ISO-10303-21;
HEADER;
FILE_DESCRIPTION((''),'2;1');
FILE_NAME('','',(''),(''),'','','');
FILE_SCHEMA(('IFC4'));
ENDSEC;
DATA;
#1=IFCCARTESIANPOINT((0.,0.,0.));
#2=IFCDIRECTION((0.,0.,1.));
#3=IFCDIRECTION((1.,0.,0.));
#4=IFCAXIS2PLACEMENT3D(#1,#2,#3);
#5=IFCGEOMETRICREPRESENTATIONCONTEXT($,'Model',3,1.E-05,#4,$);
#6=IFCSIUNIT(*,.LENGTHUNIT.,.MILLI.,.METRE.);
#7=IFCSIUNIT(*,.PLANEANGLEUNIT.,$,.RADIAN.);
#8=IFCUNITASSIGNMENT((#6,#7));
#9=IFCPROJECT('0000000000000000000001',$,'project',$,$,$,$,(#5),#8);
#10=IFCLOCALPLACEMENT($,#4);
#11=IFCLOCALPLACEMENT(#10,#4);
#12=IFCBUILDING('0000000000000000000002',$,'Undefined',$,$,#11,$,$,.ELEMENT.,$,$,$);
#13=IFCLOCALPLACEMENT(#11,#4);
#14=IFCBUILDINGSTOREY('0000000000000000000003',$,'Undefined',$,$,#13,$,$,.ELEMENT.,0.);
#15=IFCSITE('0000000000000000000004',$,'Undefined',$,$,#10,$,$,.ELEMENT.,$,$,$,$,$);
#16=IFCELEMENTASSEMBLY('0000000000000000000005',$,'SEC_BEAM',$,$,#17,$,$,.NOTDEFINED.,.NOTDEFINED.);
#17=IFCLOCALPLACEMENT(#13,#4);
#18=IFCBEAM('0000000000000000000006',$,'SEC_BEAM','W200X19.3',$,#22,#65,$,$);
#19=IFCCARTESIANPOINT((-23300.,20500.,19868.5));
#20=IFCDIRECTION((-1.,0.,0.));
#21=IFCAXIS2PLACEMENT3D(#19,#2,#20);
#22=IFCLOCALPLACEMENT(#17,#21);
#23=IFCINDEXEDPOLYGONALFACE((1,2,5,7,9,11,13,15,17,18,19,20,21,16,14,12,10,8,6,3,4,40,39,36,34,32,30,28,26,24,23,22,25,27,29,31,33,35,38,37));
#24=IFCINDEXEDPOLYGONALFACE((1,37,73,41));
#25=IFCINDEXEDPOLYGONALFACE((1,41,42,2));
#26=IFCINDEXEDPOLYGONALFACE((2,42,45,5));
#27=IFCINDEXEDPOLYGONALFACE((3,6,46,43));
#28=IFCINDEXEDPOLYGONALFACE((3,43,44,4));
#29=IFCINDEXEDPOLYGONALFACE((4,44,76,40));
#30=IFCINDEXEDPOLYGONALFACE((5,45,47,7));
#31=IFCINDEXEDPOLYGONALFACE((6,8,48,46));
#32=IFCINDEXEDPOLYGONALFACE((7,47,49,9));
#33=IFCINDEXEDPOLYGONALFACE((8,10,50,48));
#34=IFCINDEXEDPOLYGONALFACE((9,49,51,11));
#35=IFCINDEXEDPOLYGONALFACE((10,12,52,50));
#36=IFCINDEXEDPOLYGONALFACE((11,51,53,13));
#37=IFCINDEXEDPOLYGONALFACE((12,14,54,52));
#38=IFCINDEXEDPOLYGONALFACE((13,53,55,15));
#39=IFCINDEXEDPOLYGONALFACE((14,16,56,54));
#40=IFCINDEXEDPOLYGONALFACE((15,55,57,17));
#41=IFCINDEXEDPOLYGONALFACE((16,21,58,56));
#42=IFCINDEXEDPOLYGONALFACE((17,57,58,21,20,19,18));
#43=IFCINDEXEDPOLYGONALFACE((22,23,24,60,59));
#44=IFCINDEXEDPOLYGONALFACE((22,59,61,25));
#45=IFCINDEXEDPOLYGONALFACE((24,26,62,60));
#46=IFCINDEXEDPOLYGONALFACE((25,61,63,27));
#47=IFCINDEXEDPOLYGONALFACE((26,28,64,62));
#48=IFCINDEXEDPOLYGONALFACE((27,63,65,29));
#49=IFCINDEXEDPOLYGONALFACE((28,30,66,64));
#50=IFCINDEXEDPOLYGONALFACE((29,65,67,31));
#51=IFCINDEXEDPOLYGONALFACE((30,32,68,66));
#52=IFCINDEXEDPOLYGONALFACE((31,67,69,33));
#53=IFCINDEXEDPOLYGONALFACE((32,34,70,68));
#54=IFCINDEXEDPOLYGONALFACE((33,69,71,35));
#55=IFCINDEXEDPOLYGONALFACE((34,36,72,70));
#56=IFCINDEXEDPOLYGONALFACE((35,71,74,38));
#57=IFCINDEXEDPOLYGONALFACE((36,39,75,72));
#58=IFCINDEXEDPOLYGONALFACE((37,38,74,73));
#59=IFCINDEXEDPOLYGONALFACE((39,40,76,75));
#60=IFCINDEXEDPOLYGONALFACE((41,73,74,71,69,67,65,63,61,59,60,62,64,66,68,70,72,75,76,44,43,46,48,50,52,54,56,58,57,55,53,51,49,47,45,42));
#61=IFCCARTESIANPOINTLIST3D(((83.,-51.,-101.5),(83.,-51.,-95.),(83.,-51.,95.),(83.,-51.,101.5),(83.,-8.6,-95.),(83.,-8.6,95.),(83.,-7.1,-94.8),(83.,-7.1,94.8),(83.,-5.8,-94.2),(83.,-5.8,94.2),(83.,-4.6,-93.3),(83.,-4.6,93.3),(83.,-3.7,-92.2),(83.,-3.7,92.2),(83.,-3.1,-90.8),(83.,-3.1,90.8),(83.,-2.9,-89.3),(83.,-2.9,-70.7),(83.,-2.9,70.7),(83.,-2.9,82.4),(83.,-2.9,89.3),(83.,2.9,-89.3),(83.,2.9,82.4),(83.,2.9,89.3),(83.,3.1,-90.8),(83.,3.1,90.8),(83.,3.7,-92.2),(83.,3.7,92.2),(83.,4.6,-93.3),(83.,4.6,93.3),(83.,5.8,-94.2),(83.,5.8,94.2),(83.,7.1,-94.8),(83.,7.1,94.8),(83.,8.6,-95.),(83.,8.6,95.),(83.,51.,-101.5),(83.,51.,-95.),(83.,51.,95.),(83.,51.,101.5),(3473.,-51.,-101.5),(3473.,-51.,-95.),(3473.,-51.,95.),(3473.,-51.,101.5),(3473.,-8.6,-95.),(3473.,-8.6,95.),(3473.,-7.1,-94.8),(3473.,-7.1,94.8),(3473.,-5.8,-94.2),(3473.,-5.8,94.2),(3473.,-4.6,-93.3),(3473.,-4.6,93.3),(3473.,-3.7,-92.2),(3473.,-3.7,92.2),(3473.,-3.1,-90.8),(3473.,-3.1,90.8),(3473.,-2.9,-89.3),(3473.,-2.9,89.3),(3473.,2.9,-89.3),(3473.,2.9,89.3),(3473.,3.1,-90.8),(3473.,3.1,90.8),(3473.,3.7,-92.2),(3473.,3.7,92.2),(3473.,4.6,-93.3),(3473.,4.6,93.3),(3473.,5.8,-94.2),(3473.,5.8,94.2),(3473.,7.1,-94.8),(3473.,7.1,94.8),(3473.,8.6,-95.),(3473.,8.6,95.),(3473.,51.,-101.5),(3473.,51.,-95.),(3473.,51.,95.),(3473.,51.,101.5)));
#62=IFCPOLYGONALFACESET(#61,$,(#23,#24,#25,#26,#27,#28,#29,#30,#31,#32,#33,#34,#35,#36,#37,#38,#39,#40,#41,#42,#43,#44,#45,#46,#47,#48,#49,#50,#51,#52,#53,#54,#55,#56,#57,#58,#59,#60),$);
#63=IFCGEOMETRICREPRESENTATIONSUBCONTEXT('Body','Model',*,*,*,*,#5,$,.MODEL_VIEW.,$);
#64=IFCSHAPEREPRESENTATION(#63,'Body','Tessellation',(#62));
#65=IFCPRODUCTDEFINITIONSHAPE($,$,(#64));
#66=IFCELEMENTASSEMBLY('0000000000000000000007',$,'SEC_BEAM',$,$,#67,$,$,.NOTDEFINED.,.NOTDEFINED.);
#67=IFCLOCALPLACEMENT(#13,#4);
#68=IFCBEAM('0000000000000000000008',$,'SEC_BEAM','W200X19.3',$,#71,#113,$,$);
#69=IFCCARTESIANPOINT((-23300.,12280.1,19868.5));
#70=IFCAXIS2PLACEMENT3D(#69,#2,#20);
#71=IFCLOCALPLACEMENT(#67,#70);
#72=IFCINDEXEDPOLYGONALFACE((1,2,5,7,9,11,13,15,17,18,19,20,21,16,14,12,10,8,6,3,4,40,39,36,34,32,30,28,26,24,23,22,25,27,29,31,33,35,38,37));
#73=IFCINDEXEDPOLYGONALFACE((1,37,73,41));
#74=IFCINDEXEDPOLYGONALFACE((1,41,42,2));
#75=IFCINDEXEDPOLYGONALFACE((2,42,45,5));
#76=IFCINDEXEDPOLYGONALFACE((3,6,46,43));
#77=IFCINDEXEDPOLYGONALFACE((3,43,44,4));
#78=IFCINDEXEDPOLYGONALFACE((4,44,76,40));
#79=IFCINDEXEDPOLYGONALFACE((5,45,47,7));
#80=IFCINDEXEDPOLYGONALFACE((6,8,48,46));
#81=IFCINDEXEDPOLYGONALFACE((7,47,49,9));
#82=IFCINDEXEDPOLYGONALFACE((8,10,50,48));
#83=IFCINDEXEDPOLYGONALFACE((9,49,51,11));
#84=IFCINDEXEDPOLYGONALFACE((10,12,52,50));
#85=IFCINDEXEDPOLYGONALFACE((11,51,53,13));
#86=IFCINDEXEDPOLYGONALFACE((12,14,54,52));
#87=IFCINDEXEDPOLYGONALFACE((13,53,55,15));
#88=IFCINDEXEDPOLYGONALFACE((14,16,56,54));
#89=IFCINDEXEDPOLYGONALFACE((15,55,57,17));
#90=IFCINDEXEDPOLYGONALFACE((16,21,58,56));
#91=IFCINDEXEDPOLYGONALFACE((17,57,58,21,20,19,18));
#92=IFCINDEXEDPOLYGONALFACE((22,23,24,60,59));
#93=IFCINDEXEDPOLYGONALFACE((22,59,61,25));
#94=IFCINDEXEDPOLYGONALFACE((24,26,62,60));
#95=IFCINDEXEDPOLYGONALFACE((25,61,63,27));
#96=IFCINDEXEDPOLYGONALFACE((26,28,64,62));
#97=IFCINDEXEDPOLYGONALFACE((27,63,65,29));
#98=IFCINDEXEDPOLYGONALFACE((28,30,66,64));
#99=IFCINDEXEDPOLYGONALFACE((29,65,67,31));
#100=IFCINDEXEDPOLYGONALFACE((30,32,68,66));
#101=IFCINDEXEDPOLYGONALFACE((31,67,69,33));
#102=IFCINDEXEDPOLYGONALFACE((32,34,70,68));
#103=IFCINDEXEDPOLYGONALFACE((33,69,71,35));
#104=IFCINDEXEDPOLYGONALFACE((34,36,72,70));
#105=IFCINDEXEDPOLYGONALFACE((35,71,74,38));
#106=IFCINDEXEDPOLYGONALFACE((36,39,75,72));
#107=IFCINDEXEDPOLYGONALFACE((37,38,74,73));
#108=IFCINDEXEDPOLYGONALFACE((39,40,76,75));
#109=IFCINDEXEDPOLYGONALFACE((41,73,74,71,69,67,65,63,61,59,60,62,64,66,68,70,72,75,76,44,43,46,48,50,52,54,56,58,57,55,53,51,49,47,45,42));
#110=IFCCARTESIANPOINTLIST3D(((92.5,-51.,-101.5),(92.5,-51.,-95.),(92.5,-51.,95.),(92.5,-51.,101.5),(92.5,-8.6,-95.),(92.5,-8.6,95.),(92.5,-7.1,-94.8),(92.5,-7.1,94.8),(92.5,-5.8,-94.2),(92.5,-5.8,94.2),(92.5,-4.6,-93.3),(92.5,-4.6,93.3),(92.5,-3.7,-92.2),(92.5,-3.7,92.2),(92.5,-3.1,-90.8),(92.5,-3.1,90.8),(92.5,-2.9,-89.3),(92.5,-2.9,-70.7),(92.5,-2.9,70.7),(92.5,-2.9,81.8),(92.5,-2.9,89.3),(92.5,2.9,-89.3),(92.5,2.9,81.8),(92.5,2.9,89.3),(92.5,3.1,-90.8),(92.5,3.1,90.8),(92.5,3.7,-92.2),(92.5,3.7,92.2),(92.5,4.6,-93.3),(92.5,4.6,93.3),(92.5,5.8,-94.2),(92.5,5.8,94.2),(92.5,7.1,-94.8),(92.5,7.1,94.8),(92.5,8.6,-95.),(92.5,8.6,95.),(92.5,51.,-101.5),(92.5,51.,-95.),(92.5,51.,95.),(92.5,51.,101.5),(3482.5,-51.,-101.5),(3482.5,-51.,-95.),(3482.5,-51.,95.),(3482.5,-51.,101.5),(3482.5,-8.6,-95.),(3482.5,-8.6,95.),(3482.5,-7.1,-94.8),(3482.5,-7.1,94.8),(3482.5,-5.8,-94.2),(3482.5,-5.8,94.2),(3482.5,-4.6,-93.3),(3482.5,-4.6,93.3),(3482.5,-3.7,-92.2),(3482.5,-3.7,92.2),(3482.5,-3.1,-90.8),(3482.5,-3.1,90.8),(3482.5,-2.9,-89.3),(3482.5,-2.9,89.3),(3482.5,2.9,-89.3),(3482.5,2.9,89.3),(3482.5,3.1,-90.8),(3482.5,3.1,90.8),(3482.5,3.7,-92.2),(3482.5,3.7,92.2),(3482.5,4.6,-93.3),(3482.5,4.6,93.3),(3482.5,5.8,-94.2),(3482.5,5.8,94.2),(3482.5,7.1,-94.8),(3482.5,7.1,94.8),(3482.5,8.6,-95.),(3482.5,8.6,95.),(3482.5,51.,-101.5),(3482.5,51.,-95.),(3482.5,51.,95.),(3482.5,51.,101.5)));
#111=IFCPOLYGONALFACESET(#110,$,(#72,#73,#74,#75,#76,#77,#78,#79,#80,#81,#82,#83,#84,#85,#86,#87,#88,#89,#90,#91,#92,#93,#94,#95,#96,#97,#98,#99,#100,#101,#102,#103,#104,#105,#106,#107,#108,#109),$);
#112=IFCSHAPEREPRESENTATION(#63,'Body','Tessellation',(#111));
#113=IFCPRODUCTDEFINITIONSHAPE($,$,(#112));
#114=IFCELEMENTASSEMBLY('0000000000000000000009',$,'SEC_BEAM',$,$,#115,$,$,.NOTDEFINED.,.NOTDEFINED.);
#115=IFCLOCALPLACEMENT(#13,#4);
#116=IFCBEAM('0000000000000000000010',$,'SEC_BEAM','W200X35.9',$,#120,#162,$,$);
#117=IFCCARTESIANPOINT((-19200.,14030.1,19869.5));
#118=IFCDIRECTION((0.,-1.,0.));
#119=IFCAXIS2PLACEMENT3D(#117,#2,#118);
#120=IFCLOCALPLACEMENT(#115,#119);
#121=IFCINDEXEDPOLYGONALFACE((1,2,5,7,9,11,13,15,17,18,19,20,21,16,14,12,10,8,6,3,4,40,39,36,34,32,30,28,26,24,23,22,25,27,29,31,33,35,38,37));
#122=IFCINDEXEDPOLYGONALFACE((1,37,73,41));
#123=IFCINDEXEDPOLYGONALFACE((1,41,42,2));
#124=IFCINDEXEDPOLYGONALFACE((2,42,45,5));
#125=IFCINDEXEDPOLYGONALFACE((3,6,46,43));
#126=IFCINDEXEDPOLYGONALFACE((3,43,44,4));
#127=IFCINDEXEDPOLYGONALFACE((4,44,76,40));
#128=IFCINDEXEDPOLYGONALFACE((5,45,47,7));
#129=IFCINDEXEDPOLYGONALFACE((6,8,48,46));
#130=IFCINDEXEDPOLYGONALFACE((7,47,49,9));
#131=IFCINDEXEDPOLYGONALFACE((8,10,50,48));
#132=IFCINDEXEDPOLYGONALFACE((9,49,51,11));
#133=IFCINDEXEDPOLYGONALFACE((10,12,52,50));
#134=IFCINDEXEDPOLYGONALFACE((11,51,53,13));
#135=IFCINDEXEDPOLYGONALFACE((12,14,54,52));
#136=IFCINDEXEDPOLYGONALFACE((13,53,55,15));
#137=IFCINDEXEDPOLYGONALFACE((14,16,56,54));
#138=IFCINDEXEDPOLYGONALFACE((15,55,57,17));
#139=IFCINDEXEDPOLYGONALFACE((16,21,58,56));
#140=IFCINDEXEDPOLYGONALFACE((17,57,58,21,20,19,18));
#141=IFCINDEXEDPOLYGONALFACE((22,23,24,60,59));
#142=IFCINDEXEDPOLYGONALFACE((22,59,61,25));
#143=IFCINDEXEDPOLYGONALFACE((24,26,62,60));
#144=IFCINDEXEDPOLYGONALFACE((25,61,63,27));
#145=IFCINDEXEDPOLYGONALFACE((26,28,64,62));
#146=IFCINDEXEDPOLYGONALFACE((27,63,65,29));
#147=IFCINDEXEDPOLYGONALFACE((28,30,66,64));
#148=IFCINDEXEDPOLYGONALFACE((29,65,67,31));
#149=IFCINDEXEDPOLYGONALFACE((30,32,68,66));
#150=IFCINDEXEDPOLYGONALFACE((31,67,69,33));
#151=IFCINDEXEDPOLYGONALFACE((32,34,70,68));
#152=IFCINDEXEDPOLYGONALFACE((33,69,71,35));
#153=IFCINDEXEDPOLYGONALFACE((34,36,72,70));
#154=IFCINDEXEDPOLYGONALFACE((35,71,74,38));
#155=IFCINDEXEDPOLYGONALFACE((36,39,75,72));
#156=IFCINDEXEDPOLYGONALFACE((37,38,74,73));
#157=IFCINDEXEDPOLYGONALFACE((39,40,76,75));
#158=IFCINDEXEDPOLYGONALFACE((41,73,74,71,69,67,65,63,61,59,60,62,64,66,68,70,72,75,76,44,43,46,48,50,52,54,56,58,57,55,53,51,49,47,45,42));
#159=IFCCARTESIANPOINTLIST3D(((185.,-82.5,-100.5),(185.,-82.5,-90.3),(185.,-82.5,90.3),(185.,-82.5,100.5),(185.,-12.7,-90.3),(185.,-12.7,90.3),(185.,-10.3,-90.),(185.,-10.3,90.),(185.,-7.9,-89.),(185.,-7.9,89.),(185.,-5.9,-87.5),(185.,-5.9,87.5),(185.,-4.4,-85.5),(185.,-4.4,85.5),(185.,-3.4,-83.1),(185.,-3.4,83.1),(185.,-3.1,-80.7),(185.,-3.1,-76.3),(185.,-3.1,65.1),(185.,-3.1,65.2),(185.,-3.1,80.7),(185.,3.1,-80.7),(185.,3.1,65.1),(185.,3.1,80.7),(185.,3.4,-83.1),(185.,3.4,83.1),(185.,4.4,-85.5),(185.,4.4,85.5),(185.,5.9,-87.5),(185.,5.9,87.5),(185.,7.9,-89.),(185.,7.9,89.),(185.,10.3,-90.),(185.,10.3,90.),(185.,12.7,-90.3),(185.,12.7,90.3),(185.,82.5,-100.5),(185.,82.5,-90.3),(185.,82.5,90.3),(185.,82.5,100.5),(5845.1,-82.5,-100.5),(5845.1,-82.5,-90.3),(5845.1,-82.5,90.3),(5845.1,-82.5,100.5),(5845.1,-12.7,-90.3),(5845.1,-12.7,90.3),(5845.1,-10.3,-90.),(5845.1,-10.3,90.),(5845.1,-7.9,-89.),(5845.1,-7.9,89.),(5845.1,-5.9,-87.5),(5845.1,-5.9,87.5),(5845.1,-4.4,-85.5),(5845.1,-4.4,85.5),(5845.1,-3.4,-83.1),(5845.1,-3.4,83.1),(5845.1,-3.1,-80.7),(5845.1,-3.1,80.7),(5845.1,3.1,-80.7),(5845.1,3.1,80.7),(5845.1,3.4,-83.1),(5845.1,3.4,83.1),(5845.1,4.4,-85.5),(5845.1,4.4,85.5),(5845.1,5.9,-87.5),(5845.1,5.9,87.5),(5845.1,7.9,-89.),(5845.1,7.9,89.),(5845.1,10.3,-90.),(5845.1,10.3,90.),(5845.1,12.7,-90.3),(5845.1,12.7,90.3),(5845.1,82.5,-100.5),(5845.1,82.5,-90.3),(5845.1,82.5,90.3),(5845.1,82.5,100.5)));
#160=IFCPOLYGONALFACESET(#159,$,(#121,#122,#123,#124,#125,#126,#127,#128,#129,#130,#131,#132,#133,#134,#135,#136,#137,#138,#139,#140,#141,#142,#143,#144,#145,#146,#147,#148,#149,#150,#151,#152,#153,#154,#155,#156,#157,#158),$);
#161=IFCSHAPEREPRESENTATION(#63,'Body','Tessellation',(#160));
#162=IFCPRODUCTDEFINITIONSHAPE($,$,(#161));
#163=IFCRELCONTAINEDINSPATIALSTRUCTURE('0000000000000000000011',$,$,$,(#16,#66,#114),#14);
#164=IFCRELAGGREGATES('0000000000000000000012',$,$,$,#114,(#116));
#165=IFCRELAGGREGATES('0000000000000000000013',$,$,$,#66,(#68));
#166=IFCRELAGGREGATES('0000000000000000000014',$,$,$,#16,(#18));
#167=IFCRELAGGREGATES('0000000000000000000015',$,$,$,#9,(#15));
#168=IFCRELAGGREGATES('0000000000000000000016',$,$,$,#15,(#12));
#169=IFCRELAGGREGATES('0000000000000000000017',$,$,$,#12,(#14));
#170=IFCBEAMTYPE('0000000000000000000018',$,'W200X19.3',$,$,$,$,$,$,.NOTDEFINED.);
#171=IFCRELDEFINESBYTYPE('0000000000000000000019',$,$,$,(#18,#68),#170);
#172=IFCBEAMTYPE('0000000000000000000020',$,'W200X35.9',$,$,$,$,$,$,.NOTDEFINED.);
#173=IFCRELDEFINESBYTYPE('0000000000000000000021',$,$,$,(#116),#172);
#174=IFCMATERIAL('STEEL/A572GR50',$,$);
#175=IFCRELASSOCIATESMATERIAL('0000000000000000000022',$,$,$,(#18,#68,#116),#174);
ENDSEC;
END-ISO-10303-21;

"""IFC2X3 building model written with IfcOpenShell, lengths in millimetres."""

from ifc_helpers import new_model, si_unit, frame, origin_with_axes, origin_2d_with_axis, place, context, subcontext, project, spatial, polyline, rectangle, i_section, outline, extrude, boolean, halfspace, material, type_object, element, aggregate, save


model = new_model("IFC2X3")

# Units and contexts
model_context = context("Model", 3, precision=1e-05, world=origin_with_axes())
body_context = subcontext(model_context, "Body", "Model", "MODEL_VIEW")
ifc_project = project(units=[si_unit("LENGTHUNIT", "METRE", prefix="MILLI"), si_unit("PLANEANGLEUNIT", "RADIAN")], contexts=[model_context])

# Site, building, storey
site_placement = place(None, origin_with_axes())
site = spatial("IfcSite", under=ifc_project, at=site_placement, Name="Undefined", CompositionType="ELEMENT")
building_placement = place(site_placement, origin_with_axes())
building = spatial("IfcBuilding", under=site, at=building_placement, Name="Undefined", CompositionType="ELEMENT")
storey_placement = place(building_placement, origin_with_axes())
storey = spatial("IfcBuildingStorey", under=building, at=storey_placement, Name="Undefined", CompositionType="ELEMENT", Elevation=0.0)

# Element assemblies, beams
assembly_1_placement = place(storey_placement, origin_with_axes())
assembly_1 = element("IfcElementAssembly", 1, at=assembly_1_placement, inside=storey, Name="SEC_BEAM", AssemblyPlace="NOTDEFINED", PredefinedType="NOTDEFINED")
ifc_material_1 = material(Name="STEEL/A572GR50")
beam_type_1 = type_object("IfcBeamType", Name="W200X19.3", PredefinedType="NOTDEFINED")
beam_1_placement = place(assembly_1_placement, frame((-23300.0, 20500.0, 19868.5), z_axis=(0.0, 0.0, 1.0), x_axis=(-1.0, 0.0, 0.0)))
beam_1 = element("IfcBeam", 2, at=beam_1_placement, type_object=beam_type_1, material=ifc_material_1, Name="SEC_BEAM", Description="W200X19.3", context=body_context, shape_type="CSG", body=[
    boolean("DIFFERENCE", boolean("DIFFERENCE", boolean("DIFFERENCE", boolean("DIFFERENCE", extrude(i_section(OverallWidth=102.0, OverallDepth=203.0, WebThickness=5.8, FlangeThickness=6.5, FilletRadius=5.7, at=origin_2d_with_axis()), frame((3473.0, 0.0, 0.0), z_axis=(-1.0, 0.0, 0.0), x_axis=(0.0, -1.0, 0.0)), (0.0, 0.0, 1.0), 3473.0), extrude(outline(polyline([(0.0, 0.0), (29.1, 0.0), (29.1, 10.0), (0.0, 10.0), (0.0, 0.0)])), frame((83.0, 61.0, 82.4), z_axis=(0.0, -1.0, 0.0), x_axis=(0.0, 0.0, 1.0)), (0.0, 0.0, 1.0), 122.0)), extrude(rectangle(XDim=149.9, YDim=149.9, at=origin_2d_with_axis()), frame((78.0, -77.9, 70.7), z_axis=(0.0, 0.0, -1.0), x_axis=(1.0, 0.0, 0.0)), (0.0, 0.0, 1.0), 141.5)), halfspace(frame((3473.0, 0.0, 0.0), z_axis=(-1.0, 0.0, 0.0), x_axis=(0.0, 1.0, 0.0)), True)), halfspace(frame((83.0, 0.0, 201.5), z_axis=(-1.0, 0.0, 0.0), x_axis=(0.0, -1.0, 0.0)), False)),
])
assembly_2_placement = place(storey_placement, origin_with_axes())
assembly_2 = element("IfcElementAssembly", 3, at=assembly_2_placement, inside=storey, Name="SEC_BEAM", AssemblyPlace="NOTDEFINED", PredefinedType="NOTDEFINED")
beam_2_placement = place(assembly_2_placement, frame((-23300.0, 12280.1, 19868.5), z_axis=(0.0, 0.0, 1.0), x_axis=(-1.0, 0.0, 0.0)))
beam_2 = element("IfcBeam", 4, at=beam_2_placement, type_object=beam_type_1, material=ifc_material_1, Name="SEC_BEAM", Description="W200X19.3", context=body_context, shape_type="CSG", body=[
    boolean("DIFFERENCE", boolean("DIFFERENCE", boolean("DIFFERENCE", boolean("DIFFERENCE", extrude(i_section(OverallWidth=102.0, OverallDepth=203.0, WebThickness=5.8, FlangeThickness=6.5, FilletRadius=5.7, at=origin_2d_with_axis()), frame((3482.5, 0.0, 0.0), z_axis=(-1.0, 0.0, 0.0), x_axis=(0.0, -1.0, 0.0)), (0.0, 0.0, 1.0), 3482.5), extrude(outline(polyline([(0.0, 0.0), (29.7, 0.0), (29.7, 10.0), (0.0, 10.0), (0.0, 0.0)])), frame((92.5, 61.0, 81.8), z_axis=(0.0, -1.0, 0.0), x_axis=(0.0, 0.0, 1.0)), (0.0, 0.0, 1.0), 122.0)), extrude(rectangle(XDim=159.6, YDim=159.6, at=origin_2d_with_axis()), frame((82.7, -82.7, 70.7), z_axis=(0.0, 0.0, -1.0), x_axis=(1.0, 0.0, 0.0)), (0.0, 0.0, 1.0), 141.5)), halfspace(frame((3482.5, 0.0, 0.0), z_axis=(-1.0, 0.0, 0.0), x_axis=(0.0, 1.0, 0.0)), True)), halfspace(frame((92.5, 0.0, 201.5), z_axis=(-1.0, 0.0, 0.0), x_axis=(0.0, -1.0, 0.0)), False)),
])

# Element assembly, beam
assembly_3_placement = place(storey_placement, origin_with_axes())
assembly_3 = element("IfcElementAssembly", 5, at=assembly_3_placement, inside=storey, Name="SEC_BEAM", AssemblyPlace="NOTDEFINED", PredefinedType="NOTDEFINED")
beam_type_2 = type_object("IfcBeamType", Name="W200X35.9", PredefinedType="NOTDEFINED")
beam_3_placement = place(assembly_3_placement, frame((-19200.0, 14030.1, 19869.5), z_axis=(0.0, 0.0, 1.0), x_axis=(0.0, -1.0, 0.0)))
beam_3 = element("IfcBeam", 6, at=beam_3_placement, type_object=beam_type_2, material=ifc_material_1, Name="SEC_BEAM", Description="W200X35.9", context=body_context, shape_type="CSG", body=[
    boolean("DIFFERENCE", boolean("DIFFERENCE", boolean("DIFFERENCE", boolean("DIFFERENCE", extrude(i_section(OverallWidth=165.0, OverallDepth=201.0, WebThickness=6.2, FlangeThickness=10.2, FilletRadius=9.7, at=origin_2d_with_axis()), frame((5845.1, 0.0, 0.0), z_axis=(-1.0, 0.0, 0.0), x_axis=(0.0, -1.0, 0.0)), (0.0, 0.0, 1.0), 5845.1), extrude(outline(polyline([(0.0, 0.0), (45.4, 0.0), (45.4, 10.0), (0.0, 10.0), (0.0, 0.0)])), frame((185.0, 92.5, 65.1), z_axis=(0.0, -1.0, 0.0), x_axis=(0.0, 0.0, 1.0)), (0.0, 0.0, 1.0), 185.0)), extrude(rectangle(XDim=251.0, YDim=251.0, at=origin_2d_with_axis()), frame((129.5, -128.6, 65.2), z_axis=(0.0, 0.0, -1.0), x_axis=(1.0, 0.0, 0.0)), (0.0, 0.0, 1.0), 141.5)), halfspace(frame((5845.1, 0.0, 0.0), z_axis=(-1.0, 0.0, 0.0), x_axis=(0.0, 1.0, 0.0)), True)), halfspace(frame((185.0, 0.0, 200.5), z_axis=(-1.0, 0.0, 0.0), x_axis=(0.0, -1.0, 0.0)), False)),
])

aggregate(assembly_3, [beam_3])
aggregate(assembly_2, [beam_2])
aggregate(assembly_1, [beam_1])

save(model, "model.ifc")
